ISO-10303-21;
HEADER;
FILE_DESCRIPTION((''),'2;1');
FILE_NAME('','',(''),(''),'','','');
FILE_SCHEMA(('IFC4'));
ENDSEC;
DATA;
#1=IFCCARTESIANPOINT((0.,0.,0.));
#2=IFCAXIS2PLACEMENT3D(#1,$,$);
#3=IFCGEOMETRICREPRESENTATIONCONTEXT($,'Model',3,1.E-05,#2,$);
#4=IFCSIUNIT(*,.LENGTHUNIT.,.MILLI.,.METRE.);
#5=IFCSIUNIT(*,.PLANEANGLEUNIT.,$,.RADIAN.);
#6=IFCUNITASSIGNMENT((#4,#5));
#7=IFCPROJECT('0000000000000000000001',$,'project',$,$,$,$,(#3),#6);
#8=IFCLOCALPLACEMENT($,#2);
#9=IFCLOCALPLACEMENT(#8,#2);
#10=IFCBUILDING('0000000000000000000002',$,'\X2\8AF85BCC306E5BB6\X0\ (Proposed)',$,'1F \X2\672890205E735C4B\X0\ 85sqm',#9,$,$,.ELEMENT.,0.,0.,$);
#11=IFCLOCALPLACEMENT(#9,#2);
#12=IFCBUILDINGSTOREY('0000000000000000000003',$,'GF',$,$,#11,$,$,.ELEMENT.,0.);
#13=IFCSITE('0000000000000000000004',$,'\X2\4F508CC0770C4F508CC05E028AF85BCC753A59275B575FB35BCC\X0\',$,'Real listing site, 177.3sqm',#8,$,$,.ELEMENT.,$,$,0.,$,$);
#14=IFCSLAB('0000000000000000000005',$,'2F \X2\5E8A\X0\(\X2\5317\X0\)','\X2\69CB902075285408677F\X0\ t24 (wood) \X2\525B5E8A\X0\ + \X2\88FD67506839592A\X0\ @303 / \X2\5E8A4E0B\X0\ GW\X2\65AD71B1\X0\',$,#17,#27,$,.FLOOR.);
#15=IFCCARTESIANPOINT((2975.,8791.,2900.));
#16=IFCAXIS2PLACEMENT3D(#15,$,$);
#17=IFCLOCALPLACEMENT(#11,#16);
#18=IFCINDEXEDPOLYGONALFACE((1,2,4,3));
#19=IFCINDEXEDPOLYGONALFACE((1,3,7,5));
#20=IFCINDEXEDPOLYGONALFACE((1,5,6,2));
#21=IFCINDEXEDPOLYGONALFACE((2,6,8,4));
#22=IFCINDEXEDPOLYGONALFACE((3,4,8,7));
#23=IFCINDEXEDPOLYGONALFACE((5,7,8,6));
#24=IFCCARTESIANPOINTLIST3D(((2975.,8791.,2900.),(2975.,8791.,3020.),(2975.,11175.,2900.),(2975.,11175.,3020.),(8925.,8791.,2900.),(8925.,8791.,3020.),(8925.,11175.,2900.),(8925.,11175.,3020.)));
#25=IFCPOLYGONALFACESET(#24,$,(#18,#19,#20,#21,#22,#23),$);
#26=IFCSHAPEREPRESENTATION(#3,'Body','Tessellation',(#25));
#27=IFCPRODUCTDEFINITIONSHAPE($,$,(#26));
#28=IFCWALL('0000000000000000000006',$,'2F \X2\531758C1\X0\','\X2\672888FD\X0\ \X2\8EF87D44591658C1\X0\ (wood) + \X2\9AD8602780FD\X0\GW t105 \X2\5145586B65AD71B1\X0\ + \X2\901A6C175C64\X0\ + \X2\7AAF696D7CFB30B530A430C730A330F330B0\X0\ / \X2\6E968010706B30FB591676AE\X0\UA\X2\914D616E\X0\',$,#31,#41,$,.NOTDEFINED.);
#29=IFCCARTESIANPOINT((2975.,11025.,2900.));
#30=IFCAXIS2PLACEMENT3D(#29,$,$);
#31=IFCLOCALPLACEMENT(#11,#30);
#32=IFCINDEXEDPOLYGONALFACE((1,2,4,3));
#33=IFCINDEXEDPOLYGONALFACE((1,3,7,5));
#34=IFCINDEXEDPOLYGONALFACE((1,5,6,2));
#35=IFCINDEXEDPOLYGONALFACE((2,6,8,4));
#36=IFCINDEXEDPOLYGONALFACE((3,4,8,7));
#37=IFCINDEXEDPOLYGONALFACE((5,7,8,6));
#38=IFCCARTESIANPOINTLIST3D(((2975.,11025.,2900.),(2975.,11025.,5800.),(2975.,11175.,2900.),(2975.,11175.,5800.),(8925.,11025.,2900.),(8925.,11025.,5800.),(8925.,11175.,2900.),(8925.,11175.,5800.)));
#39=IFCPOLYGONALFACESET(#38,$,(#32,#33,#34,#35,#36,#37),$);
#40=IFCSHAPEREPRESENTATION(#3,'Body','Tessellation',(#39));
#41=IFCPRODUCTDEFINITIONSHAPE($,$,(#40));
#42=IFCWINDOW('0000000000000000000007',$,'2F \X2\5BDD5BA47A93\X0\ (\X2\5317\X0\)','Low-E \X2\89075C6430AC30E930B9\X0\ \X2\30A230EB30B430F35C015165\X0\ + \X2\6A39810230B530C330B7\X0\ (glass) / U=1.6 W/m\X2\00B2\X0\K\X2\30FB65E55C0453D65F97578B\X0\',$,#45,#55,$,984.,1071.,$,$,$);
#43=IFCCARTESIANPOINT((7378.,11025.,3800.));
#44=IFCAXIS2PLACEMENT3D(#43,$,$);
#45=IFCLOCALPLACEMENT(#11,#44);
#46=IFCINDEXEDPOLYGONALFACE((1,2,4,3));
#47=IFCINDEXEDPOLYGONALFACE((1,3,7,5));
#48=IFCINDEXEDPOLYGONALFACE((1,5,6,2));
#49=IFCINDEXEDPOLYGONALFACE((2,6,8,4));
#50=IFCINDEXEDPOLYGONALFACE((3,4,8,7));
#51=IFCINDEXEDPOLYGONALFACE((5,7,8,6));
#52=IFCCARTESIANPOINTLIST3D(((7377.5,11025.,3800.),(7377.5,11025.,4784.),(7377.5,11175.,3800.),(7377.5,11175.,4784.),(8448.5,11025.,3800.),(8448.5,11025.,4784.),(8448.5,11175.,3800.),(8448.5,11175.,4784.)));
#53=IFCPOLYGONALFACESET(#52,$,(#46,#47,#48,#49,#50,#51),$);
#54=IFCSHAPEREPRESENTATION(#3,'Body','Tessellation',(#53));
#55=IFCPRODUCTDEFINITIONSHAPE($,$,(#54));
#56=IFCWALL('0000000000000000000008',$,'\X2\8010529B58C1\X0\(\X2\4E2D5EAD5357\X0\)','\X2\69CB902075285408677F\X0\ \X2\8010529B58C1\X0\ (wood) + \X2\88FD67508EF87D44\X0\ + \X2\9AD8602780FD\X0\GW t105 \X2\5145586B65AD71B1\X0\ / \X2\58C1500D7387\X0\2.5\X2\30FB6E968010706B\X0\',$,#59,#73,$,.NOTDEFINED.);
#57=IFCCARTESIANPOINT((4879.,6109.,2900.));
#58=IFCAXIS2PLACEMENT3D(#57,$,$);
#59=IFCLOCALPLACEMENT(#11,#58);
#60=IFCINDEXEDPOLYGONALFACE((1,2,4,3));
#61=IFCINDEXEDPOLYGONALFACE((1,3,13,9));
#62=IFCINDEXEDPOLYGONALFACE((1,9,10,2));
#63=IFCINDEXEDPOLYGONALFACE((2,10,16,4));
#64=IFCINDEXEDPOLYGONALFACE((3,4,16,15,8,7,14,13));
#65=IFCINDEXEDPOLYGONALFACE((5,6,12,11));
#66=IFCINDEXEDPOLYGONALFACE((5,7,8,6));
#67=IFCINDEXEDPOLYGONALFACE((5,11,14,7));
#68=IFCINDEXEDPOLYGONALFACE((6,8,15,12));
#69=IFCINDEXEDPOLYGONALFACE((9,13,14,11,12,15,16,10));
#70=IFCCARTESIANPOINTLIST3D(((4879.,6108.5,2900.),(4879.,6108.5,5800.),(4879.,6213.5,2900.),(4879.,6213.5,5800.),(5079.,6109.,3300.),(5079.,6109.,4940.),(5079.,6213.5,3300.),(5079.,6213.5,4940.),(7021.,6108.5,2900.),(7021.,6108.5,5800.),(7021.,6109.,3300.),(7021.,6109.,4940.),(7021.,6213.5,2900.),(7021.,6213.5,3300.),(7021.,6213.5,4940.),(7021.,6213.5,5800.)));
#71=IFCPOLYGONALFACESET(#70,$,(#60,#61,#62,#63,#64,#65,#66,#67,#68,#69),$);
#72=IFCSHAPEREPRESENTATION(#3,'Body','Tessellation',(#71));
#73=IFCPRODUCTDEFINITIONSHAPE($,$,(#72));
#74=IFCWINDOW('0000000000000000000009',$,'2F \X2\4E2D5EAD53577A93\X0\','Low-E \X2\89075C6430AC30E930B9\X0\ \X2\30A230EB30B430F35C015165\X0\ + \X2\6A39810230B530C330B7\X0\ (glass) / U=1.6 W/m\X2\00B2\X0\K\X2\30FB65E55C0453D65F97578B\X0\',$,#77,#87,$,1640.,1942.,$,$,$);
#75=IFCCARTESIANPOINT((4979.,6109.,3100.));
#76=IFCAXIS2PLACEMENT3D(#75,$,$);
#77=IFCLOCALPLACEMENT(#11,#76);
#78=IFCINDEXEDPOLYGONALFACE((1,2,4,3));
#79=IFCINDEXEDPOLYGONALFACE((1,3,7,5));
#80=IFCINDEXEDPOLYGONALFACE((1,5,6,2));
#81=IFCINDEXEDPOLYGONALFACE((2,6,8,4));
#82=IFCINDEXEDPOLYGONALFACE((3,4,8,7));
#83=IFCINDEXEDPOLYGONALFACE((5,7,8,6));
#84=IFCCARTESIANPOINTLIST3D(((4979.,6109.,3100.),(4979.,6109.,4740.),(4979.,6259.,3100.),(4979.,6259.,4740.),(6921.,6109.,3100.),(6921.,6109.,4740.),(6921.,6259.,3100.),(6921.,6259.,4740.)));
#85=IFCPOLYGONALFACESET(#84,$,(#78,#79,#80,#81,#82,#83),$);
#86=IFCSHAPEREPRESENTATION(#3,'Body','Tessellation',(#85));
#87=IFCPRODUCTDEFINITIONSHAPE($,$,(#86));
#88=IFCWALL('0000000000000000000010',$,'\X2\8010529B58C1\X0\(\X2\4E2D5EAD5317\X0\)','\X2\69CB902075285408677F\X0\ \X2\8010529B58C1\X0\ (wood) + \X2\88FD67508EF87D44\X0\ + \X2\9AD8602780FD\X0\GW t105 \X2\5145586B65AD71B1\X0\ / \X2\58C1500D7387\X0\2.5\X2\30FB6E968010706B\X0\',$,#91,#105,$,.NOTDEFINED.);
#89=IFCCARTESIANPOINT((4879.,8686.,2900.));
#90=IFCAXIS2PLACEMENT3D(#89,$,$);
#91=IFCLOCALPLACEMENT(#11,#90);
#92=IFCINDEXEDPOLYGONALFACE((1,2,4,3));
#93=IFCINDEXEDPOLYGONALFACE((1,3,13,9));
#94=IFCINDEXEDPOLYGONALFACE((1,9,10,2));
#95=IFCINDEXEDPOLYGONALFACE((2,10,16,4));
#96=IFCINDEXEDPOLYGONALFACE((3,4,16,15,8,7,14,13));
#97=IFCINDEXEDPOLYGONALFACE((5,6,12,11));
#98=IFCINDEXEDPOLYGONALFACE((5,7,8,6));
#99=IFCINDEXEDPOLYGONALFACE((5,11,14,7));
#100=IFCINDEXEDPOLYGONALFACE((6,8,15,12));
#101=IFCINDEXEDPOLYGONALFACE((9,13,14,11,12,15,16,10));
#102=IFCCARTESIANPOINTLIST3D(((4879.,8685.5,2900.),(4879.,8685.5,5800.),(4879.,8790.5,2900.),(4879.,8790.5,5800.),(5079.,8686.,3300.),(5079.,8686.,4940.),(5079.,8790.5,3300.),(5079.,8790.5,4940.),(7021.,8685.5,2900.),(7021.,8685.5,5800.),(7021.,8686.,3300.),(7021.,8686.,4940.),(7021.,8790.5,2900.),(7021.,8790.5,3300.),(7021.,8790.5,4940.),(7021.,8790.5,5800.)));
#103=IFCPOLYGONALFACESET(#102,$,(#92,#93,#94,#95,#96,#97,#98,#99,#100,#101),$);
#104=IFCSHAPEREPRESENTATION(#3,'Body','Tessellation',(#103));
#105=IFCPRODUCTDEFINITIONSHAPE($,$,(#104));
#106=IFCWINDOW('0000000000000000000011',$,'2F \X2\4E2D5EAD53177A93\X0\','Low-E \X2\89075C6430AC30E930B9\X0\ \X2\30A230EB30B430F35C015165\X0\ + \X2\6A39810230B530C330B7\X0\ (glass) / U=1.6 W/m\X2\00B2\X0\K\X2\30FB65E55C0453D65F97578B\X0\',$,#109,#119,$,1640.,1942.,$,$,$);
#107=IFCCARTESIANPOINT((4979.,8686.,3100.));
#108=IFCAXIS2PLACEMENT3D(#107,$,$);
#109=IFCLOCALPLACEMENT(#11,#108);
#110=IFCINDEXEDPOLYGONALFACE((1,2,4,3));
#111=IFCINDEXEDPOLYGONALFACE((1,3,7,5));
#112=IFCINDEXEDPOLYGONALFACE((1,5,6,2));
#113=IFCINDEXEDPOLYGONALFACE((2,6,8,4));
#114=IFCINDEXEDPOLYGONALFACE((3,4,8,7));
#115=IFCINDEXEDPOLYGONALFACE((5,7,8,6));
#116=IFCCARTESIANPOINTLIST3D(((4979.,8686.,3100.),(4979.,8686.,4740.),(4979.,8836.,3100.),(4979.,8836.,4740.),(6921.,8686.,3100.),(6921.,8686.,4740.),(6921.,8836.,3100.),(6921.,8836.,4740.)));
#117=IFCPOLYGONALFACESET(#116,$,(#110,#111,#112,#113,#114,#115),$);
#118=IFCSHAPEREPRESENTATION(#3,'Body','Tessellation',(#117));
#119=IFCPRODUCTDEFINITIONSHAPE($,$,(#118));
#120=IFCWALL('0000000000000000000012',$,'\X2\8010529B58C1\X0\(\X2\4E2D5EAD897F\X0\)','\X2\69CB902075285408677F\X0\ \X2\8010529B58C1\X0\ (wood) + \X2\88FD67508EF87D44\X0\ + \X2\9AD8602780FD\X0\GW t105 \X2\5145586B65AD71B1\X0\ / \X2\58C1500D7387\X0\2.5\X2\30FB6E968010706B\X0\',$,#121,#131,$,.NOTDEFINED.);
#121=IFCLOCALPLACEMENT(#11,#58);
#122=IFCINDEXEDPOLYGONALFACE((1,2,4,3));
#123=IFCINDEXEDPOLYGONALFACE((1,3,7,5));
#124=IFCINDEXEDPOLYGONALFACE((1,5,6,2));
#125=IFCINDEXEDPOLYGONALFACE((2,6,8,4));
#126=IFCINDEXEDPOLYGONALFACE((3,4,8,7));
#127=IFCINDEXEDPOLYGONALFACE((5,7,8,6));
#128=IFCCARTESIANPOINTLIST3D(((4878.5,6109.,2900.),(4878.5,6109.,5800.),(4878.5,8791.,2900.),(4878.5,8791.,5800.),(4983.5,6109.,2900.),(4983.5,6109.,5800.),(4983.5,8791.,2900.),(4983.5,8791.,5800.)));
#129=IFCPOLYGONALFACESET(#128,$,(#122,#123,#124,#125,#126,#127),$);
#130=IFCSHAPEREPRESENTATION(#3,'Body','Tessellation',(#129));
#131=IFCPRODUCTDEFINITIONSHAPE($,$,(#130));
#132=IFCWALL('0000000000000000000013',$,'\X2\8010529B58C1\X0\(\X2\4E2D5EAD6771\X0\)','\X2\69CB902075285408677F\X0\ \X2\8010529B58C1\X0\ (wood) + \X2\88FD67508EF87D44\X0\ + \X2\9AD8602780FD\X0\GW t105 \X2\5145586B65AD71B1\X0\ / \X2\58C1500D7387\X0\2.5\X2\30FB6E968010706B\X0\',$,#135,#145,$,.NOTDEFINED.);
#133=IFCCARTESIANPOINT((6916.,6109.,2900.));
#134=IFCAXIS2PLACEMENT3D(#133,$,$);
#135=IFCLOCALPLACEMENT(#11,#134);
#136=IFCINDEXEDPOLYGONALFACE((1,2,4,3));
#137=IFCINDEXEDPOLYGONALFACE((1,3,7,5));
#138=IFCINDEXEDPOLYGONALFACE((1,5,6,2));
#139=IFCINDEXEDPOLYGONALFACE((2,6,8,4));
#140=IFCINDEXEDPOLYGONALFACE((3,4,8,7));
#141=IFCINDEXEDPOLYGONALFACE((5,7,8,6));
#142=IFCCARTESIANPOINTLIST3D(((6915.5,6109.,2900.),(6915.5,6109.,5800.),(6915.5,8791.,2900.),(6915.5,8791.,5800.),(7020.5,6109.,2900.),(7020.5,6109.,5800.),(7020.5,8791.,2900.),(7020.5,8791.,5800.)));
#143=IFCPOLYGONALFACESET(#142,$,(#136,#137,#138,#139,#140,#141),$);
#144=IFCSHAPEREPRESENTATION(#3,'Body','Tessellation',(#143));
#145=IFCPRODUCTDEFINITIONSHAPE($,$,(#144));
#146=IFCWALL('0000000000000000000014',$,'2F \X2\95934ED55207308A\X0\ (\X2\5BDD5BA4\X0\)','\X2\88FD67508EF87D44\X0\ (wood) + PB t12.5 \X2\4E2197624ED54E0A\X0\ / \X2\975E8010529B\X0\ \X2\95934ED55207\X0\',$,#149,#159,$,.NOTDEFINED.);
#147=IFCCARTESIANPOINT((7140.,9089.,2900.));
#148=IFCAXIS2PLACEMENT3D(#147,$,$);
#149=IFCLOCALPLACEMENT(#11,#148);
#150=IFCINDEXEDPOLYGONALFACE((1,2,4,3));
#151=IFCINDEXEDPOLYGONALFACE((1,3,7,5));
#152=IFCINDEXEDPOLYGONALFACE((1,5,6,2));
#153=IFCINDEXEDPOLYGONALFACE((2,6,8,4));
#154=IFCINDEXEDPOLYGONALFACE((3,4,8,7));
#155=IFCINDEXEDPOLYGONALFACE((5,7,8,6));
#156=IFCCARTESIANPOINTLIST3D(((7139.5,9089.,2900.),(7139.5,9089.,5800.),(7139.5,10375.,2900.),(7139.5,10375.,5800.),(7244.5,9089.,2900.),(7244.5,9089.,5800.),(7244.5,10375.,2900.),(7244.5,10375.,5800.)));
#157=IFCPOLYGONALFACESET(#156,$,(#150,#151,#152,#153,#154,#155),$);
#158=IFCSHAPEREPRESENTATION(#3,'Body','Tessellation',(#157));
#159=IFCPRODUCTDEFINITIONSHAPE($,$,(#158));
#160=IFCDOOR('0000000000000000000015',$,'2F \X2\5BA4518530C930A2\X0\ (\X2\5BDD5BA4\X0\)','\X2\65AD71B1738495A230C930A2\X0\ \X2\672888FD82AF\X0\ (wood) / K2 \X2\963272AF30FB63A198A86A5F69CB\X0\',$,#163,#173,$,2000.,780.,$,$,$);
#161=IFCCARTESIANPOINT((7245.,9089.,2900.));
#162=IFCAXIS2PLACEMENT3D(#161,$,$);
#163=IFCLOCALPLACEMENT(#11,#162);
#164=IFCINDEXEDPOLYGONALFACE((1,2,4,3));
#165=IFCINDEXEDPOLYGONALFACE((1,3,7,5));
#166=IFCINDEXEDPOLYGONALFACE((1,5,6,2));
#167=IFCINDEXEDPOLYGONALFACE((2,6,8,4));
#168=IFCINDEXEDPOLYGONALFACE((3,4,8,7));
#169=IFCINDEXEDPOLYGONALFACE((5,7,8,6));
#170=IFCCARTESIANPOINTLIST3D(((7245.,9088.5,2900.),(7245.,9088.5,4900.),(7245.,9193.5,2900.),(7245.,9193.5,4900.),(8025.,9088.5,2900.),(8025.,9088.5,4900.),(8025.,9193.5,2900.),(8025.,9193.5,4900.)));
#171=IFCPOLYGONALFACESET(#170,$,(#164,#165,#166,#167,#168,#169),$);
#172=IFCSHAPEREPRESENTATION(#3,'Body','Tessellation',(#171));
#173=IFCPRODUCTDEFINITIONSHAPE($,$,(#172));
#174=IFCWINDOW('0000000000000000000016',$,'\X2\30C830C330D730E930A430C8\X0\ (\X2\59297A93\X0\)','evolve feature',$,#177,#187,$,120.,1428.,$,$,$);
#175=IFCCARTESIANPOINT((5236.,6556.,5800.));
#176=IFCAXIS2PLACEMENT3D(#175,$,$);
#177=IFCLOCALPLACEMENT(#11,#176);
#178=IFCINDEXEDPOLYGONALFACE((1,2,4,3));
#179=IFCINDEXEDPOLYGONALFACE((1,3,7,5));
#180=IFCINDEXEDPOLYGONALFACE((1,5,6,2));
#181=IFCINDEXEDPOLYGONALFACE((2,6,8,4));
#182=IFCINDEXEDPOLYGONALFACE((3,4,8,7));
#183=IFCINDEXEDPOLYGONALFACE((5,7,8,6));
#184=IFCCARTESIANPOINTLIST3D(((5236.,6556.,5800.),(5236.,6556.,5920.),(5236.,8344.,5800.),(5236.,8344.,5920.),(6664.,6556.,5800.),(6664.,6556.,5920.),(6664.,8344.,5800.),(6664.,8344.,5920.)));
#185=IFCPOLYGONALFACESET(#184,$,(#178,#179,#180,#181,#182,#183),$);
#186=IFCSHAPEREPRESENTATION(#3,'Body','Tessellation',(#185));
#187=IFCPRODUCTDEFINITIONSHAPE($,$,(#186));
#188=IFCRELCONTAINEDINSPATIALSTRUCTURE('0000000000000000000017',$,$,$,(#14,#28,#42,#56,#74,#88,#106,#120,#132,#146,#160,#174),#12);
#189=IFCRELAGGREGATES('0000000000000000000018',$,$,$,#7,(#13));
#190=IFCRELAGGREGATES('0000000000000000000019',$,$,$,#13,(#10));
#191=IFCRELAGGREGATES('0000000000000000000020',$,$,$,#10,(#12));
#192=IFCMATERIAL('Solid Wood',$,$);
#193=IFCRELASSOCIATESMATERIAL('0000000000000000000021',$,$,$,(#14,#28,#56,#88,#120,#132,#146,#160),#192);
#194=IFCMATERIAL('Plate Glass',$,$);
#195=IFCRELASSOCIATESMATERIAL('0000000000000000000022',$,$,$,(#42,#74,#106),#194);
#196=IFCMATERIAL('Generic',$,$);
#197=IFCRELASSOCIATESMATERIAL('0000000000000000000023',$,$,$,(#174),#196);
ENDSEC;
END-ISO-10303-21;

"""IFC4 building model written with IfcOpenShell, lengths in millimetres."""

from ifc_helpers import new_model, si_unit, frame, frame_2d, origin, place, context, project, spatial, rectangle, extrude, material, element, fill, save


model = new_model("IFC4")

# Units and contexts
model_context = context("Model", 3, precision=1e-05, world=origin())
ifc_project = project(units=[si_unit("LENGTHUNIT", "METRE", prefix="MILLI"), si_unit("PLANEANGLEUNIT", "RADIAN")], contexts=[model_context])

# Site, building, storey
site_placement = place(None, origin())
site = spatial("IfcSite", under=ifc_project, at=site_placement, Name="佐賀県佐賀市諸富町大字徳富", ObjectType="Real listing site, 177.3sqm", CompositionType="ELEMENT", RefElevation=0.0)
building_placement = place(site_placement, origin())
building = spatial("IfcBuilding", under=site, at=building_placement, Name="諸富の家 (Proposed)", ObjectType="1F 木造平屋 85sqm", CompositionType="ELEMENT", ElevationOfRefHeight=0.0, ElevationOfTerrain=0.0)
storey_placement = place(building_placement, origin())
storey = spatial("IfcBuildingStorey", under=building, at=storey_placement, Name="GF", CompositionType="ELEMENT", Elevation=0.0)

# Slab
ifc_material_1 = material(Name="Solid Wood")
slab_placement = place(storey_placement, frame((2975.0, 8791.0, 2900.0)))
element("IfcSlab", 1, at=slab_placement, inside=storey, material=ifc_material_1, Name="2F 床(北)", Description="構造用合板 t24 (wood) 剛床 + 製材根太 @303 / 床下 GW断熱", PredefinedType="FLOOR", context=model_context, shape_type="SweptSolid", body=[
    extrude(rectangle(XDim=5950.0, YDim=2384.0, at=frame_2d((2975.0, 1192.0))), frame((2975.0, 8791.0, 2900.0)), (0.0, 0.0, 1.0), 120.0),
])

# Walls, openings, windows
wall_1_placement = place(storey_placement, frame((2975.0, 11025.0, 2900.0)))
wall_1 = element("IfcWall", 2, at=wall_1_placement, inside=storey, material=ifc_material_1, Name="2F 北壁", Description="木製 軸組外壁 (wood) + 高性能GW t105 充填断熱 + 通気層 + 窯業系サイディング / 準耐火・外皮UA配慮", PredefinedType="NOTDEFINED", context=model_context, shape_type="SweptSolid", body=[
    extrude(rectangle(XDim=5950.0, YDim=150.0, at=frame_2d((2975.0, 75.0))), frame((2975.0, 11025.0, 2900.0)), (0.0, 0.0, 1.0), 2900.0),
])
opening_1_placement = place(storey_placement, frame((7378.0, 11025.0, 3800.0)))
opening_1 = element("IfcOpeningElement", 3, at=opening_1_placement, cuts=wall_1, PredefinedType="NOTDEFINED", context=model_context, shape_type="SweptSolid", body=[
    extrude(rectangle(XDim=1071.0, YDim=150.0, at=frame_2d((535.0, 75.0))), frame((7378.0, 11025.0, 3800.0)), (0.0, 0.0, 1.0), 984.0),
])
ifc_material_2 = material(Name="Plate Glass")
window_1_placement = place(storey_placement, frame((7378.0, 11025.0, 3800.0)))
window_1 = element("IfcWindow", 4, at=window_1_placement, inside=storey, material=ifc_material_2, Name="2F 寝室窓 (北)", Description="Low-E 複層ガラス アルゴン封入 + 樹脂サッシ (glass) / U=1.6 W/m²K・日射取得型", OverallHeight=984.0, OverallWidth=1071.0, context=model_context, shape_type="SweptSolid", body=[
    extrude(rectangle(XDim=1071.0, YDim=150.0, at=frame_2d((535.0, 75.0))), frame((7378.0, 11025.0, 3800.0)), (0.0, 0.0, 1.0), 984.0),
])
fill(opening_1, window_1)
wall_2_placement = place(storey_placement, frame((4879.0, 6109.0, 2900.0)))
wall_2 = element("IfcWall", 5, at=wall_2_placement, inside=storey, material=ifc_material_1, Name="耐力壁(中庭南)", Description="構造用合板 耐力壁 (wood) + 製材軸組 + 高性能GW t105 充填断熱 / 壁倍率2.5・準耐火", PredefinedType="NOTDEFINED", context=model_context, shape_type="SweptSolid", body=[
    extrude(rectangle(XDim=2142.0, YDim=105.0, at=frame_2d((1071.0, 52.0))), frame((4879.0, 6109.0, 2900.0)), (0.0, 0.0, 1.0), 2900.0),
])
opening_2_placement = place(storey_placement, frame((4979.0, 6109.0, 3100.0)))
opening_2 = element("IfcOpeningElement", 6, at=opening_2_placement, cuts=wall_2, PredefinedType="NOTDEFINED", context=model_context, shape_type="SweptSolid", body=[
    extrude(rectangle(XDim=1942.0, YDim=150.0, at=frame_2d((971.0, 75.0))), frame((4979.0, 6109.0, 3100.0)), (0.0, 0.0, 1.0), 1640.0),
])
window_2_placement = place(storey_placement, frame((4979.0, 6109.0, 3100.0)))
window_2 = element("IfcWindow", 7, at=window_2_placement, inside=storey, material=ifc_material_2, Name="2F 中庭南窓", Description="Low-E 複層ガラス アルゴン封入 + 樹脂サッシ (glass) / U=1.6 W/m²K・日射取得型", OverallHeight=1640.0, OverallWidth=1942.0, context=model_context, shape_type="SweptSolid", body=[
    extrude(rectangle(XDim=1942.0, YDim=150.0, at=frame_2d((971.0, 75.0))), frame((4979.0, 6109.0, 3100.0)), (0.0, 0.0, 1.0), 1640.0),
])
fill(opening_2, window_2)
wall_3_placement = place(storey_placement, frame((4879.0, 8686.0, 2900.0)))
wall_3 = element("IfcWall", 8, at=wall_3_placement, inside=storey, material=ifc_material_1, Name="耐力壁(中庭北)", Description="構造用合板 耐力壁 (wood) + 製材軸組 + 高性能GW t105 充填断熱 / 壁倍率2.5・準耐火", PredefinedType="NOTDEFINED", context=model_context, shape_type="SweptSolid", body=[
    extrude(rectangle(XDim=2142.0, YDim=105.0, at=frame_2d((1071.0, 52.0))), frame((4879.0, 8686.0, 2900.0)), (0.0, 0.0, 1.0), 2900.0),
])
opening_3_placement = place(storey_placement, frame((4979.0, 8686.0, 3100.0)))
opening_3 = element("IfcOpeningElement", 9, at=opening_3_placement, cuts=wall_3, PredefinedType="NOTDEFINED", context=model_context, shape_type="SweptSolid", body=[
    extrude(rectangle(XDim=1942.0, YDim=150.0, at=frame_2d((971.0, 75.0))), frame((4979.0, 8686.0, 3100.0)), (0.0, 0.0, 1.0), 1640.0),
])
window_3_placement = place(storey_placement, frame((4979.0, 8686.0, 3100.0)))
window_3 = element("IfcWindow", 10, at=window_3_placement, inside=storey, material=ifc_material_2, Name="2F 中庭北窓", Description="Low-E 複層ガラス アルゴン封入 + 樹脂サッシ (glass) / U=1.6 W/m²K・日射取得型", OverallHeight=1640.0, OverallWidth=1942.0, context=model_context, shape_type="SweptSolid", body=[
    extrude(rectangle(XDim=1942.0, YDim=150.0, at=frame_2d((971.0, 75.0))), frame((4979.0, 8686.0, 3100.0)), (0.0, 0.0, 1.0), 1640.0),
])
fill(opening_3, window_3)

# Walls
wall_4_placement = place(storey_placement, frame((4879.0, 6109.0, 2900.0)))
element("IfcWall", 11, at=wall_4_placement, inside=storey, material=ifc_material_1, Name="耐力壁(中庭西)", Description="構造用合板 耐力壁 (wood) + 製材軸組 + 高性能GW t105 充填断熱 / 壁倍率2.5・準耐火", PredefinedType="NOTDEFINED", context=model_context, shape_type="SweptSolid", body=[
    extrude(rectangle(XDim=105.0, YDim=2682.0, at=frame_2d((52.0, 1341.0))), frame((4879.0, 6109.0, 2900.0)), (0.0, 0.0, 1.0), 2900.0),
])
wall_5_placement = place(storey_placement, frame((6916.0, 6109.0, 2900.0)))
element("IfcWall", 12, at=wall_5_placement, inside=storey, material=ifc_material_1, Name="耐力壁(中庭東)", Description="構造用合板 耐力壁 (wood) + 製材軸組 + 高性能GW t105 充填断熱 / 壁倍率2.5・準耐火", PredefinedType="NOTDEFINED", context=model_context, shape_type="SweptSolid", body=[
    extrude(rectangle(XDim=105.0, YDim=2682.0, at=frame_2d((52.0, 1341.0))), frame((6916.0, 6109.0, 2900.0)), (0.0, 0.0, 1.0), 2900.0),
])
wall_6_placement = place(storey_placement, frame((7140.0, 9089.0, 2900.0)))
element("IfcWall", 13, at=wall_6_placement, inside=storey, material=ifc_material_1, Name="2F 間仕切り (寝室)", Description="製材軸組 (wood) + PB t12.5 両面仕上 / 非耐力 間仕切", PredefinedType="NOTDEFINED", context=model_context, shape_type="SweptSolid", body=[
    extrude(rectangle(XDim=105.0, YDim=1286.0, at=frame_2d((52.0, 643.0))), frame((7140.0, 9089.0, 2900.0)), (0.0, 0.0, 1.0), 2900.0),
])

# Door
door_placement = place(storey_placement, frame((7245.0, 9089.0, 2900.0)))
element("IfcDoor", 14, at=door_placement, inside=storey, material=ifc_material_1, Name="2F 室内ドア (寝室)", Description="断熱玄関ドア 木製芯 (wood) / K2 防犯・採風機構", OverallHeight=2000.0, OverallWidth=780.0, context=model_context, shape_type="SweptSolid", body=[
    extrude(rectangle(XDim=780.0, YDim=105.0, at=frame_2d((390.0, 52.0))), frame((7245.0, 9089.0, 2900.0)), (0.0, 0.0, 1.0), 2000.0),
])

# Window
ifc_material_3 = material(Name="Generic")
window_4_placement = place(storey_placement, frame((5236.0, 6556.0, 5800.0)))
element("IfcWindow", 15, at=window_4_placement, inside=storey, material=ifc_material_3, Name="トップライト (天窓)", Description="evolve feature", OverallHeight=120.0, OverallWidth=1428.0, context=model_context, shape_type="SweptSolid", body=[
    extrude(rectangle(XDim=1428.0, YDim=1788.0, at=frame_2d((714.0, 894.0))), frame((5236.0, 6556.0, 5800.0)), (0.0, 0.0, 1.0), 120.0),
])

save(model, "model.ifc")
